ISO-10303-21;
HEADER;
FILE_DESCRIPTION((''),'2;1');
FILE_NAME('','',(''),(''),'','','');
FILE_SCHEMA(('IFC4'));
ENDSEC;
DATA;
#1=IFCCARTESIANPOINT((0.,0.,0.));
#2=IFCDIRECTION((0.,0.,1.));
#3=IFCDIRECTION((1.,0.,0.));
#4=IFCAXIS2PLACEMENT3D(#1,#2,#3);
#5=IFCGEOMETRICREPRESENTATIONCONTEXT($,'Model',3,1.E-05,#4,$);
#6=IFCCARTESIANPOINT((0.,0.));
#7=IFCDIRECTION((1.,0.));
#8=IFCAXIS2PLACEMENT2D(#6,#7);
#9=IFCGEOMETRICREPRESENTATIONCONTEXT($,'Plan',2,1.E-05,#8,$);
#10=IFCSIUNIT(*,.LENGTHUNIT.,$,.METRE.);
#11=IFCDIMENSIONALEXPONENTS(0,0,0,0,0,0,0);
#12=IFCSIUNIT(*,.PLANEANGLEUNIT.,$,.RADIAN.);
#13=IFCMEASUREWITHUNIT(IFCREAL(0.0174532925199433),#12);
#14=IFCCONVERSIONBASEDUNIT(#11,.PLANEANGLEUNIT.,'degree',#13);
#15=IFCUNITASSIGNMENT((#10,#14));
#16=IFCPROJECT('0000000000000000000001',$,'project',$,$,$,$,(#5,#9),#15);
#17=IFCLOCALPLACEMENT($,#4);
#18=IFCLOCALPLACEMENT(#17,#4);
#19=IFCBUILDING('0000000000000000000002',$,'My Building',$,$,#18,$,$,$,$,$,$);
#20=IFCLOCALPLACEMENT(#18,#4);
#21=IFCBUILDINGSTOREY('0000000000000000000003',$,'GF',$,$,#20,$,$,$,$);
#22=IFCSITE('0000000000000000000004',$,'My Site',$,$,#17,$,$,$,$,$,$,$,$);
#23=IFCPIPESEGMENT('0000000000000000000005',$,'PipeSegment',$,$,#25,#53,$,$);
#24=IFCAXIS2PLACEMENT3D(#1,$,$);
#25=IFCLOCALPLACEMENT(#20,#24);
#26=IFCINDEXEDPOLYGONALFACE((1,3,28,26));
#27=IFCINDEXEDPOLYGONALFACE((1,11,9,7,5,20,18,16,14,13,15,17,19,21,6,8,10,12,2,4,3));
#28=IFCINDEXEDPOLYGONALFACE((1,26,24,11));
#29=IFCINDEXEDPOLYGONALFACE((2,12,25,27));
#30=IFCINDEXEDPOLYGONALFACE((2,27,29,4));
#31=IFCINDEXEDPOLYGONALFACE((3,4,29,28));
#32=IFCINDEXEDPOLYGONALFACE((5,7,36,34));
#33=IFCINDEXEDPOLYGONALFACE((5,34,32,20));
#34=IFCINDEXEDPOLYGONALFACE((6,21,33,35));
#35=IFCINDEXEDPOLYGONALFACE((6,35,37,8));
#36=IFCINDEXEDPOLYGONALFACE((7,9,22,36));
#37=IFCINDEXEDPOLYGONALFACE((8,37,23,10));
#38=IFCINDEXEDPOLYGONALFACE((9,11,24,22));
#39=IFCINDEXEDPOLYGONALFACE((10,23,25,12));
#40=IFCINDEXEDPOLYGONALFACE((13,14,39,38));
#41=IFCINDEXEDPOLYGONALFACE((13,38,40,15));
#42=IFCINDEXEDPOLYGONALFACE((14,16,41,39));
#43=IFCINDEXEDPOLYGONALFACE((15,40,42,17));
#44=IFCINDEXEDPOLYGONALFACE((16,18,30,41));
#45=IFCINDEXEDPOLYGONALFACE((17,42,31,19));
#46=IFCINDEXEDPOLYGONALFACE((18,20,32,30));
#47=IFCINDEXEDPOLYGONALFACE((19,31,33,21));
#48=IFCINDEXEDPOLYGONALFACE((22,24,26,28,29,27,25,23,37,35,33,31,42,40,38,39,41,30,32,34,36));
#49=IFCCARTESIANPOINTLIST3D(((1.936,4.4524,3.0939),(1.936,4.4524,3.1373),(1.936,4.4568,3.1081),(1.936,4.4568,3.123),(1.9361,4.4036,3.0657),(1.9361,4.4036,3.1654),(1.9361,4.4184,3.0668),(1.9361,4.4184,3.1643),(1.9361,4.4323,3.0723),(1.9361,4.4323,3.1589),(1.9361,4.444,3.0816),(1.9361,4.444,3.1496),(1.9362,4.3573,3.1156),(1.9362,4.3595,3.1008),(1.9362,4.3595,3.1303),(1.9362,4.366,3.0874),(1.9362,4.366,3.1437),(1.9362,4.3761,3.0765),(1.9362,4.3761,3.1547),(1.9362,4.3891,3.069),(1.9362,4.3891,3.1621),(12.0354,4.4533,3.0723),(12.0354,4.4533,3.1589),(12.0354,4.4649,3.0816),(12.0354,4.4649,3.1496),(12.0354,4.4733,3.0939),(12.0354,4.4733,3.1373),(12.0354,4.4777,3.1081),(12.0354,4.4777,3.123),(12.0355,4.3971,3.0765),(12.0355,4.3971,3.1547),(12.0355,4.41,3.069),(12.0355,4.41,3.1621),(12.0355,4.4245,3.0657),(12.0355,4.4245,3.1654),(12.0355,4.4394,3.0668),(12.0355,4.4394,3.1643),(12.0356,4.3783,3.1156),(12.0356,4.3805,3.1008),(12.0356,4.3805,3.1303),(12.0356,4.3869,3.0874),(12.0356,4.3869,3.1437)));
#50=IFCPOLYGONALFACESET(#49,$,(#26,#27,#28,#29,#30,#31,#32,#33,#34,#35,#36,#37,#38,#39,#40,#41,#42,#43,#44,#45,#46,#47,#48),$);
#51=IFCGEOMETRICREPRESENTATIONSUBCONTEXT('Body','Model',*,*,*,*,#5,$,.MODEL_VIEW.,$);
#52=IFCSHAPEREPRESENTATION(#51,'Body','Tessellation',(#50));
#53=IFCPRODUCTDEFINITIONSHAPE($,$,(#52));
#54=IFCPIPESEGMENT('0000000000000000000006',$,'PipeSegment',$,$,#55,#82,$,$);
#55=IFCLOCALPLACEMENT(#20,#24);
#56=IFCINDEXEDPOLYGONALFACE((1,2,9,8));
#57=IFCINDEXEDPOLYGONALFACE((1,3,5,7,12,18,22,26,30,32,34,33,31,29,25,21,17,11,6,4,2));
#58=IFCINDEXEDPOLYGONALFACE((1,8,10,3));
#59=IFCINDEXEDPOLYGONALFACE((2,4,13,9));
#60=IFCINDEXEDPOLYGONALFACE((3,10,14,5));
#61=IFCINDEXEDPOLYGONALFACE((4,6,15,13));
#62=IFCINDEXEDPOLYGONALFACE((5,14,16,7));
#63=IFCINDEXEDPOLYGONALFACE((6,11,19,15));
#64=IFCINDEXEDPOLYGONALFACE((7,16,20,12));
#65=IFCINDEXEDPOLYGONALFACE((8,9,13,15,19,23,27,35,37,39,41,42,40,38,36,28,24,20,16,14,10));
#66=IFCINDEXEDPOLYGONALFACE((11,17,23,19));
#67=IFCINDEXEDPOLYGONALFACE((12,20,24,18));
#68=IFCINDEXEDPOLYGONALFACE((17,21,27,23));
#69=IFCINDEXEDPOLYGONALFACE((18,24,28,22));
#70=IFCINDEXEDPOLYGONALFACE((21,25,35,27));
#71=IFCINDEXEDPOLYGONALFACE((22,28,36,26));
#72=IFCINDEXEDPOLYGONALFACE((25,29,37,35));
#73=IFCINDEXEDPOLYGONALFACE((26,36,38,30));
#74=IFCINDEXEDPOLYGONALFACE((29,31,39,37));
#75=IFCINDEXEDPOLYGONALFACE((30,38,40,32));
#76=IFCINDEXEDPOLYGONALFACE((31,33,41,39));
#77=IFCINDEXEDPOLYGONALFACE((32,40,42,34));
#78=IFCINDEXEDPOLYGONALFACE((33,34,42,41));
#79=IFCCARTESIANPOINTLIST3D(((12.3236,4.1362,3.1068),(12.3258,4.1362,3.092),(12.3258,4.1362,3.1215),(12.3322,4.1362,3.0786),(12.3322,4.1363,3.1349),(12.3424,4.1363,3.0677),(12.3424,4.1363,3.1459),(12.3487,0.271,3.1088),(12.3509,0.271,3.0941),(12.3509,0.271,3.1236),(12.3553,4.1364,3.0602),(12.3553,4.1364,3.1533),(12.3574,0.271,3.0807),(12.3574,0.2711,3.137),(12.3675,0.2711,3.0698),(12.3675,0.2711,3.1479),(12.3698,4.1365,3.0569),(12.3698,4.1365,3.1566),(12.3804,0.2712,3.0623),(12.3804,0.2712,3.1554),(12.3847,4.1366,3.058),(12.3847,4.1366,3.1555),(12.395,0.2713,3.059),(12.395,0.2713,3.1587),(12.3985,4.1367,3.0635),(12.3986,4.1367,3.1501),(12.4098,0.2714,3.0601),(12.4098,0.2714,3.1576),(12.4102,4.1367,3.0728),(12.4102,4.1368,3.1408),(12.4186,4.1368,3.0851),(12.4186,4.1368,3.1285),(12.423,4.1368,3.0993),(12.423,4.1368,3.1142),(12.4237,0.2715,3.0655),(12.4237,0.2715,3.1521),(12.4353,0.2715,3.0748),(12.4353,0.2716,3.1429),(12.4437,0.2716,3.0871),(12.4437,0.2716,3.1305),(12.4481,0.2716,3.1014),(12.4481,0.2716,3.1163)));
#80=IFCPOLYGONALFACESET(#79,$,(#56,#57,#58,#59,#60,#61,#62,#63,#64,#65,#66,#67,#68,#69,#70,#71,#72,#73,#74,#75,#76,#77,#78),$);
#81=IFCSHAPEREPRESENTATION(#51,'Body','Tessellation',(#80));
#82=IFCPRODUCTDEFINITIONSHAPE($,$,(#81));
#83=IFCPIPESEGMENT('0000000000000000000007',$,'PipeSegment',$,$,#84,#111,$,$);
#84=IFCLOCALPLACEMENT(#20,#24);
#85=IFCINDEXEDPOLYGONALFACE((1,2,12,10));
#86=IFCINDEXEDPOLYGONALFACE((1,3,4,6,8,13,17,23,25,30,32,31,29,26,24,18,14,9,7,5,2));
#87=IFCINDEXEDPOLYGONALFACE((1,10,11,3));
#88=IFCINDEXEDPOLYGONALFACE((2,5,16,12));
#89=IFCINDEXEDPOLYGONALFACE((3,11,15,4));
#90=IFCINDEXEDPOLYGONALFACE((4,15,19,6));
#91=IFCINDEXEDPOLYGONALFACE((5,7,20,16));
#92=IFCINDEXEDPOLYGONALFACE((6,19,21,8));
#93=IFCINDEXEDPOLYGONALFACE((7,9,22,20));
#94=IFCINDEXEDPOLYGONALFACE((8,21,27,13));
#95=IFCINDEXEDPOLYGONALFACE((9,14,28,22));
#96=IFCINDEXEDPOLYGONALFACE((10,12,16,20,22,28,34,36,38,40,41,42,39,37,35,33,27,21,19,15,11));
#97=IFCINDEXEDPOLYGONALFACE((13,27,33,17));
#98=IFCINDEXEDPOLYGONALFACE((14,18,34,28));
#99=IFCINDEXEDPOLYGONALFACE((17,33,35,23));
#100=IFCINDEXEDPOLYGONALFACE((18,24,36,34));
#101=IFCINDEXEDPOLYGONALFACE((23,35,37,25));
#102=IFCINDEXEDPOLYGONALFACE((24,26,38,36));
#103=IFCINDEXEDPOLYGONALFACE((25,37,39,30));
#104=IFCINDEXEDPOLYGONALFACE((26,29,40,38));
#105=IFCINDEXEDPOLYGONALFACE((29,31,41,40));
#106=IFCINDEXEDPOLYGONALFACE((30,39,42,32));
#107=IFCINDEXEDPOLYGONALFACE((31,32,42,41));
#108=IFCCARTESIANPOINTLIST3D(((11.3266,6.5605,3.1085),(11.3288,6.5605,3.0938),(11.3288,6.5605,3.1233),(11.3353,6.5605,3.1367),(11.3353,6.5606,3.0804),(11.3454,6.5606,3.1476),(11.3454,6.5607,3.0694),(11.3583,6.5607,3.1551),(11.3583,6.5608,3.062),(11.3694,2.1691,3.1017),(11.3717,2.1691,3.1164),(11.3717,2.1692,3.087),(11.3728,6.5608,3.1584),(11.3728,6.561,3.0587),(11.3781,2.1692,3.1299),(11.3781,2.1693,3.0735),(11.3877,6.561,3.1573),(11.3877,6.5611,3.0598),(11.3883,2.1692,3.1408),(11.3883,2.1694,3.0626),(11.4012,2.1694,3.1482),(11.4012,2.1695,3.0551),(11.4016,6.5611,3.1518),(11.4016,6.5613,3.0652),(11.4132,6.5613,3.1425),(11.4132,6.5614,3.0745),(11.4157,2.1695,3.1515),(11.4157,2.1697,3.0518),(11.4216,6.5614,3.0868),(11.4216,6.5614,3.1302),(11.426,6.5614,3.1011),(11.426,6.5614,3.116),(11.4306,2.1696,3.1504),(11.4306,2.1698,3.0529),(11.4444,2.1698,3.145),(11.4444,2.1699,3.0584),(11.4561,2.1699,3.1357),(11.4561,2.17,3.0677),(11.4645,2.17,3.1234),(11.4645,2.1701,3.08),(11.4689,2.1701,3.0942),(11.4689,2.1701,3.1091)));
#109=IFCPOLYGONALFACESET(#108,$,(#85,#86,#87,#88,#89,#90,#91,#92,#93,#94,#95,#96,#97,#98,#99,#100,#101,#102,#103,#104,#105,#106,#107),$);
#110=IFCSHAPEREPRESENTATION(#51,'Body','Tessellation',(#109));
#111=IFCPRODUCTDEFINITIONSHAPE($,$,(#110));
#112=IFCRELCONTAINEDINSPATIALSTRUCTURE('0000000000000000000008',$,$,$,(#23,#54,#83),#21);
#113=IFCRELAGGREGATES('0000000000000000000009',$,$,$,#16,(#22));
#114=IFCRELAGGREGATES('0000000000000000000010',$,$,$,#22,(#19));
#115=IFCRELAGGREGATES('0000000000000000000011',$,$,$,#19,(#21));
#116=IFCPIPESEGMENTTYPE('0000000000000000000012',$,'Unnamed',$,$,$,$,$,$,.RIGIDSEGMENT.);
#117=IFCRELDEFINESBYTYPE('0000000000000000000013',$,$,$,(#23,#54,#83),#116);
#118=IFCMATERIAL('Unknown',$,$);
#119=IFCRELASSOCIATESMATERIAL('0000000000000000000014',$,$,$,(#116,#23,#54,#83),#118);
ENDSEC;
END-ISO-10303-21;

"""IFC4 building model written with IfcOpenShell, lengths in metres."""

from ifc_helpers import new_model, entity, si_unit, converted_unit, frame, origin_with_axes, origin_2d_with_axis, place, context, subcontext, project, spatial, circle, extrude, material, material_profile, profile_set, profile_usage, type_object, element, save


model = new_model("IFC4")

# Units and contexts
model_context = context("Model", 3, precision=1e-05, world=origin_with_axes())
plan_context = context("Plan", 2, precision=1e-05, world=origin_2d_with_axis())
body_context_1 = subcontext(model_context, "Body", "Model", "MODEL_VIEW")
ifc_project = project(units=[si_unit("LENGTHUNIT", "METRE"), converted_unit("PLANEANGLEUNIT", "degree", entity("IfcReal", 0.0174532925199433), si_unit("PLANEANGLEUNIT", "RADIAN"), dimensions=[0, 0, 0, 0, 0, 0, 0])], contexts=[model_context, plan_context])

# Site, building, storey
site_placement = place(None, origin_with_axes())
site = spatial("IfcSite", under=ifc_project, at=site_placement, Name="My Site")
building_placement = place(site_placement, origin_with_axes())
building = spatial("IfcBuilding", under=site, at=building_placement, Name="My Building")
storey_placement = place(building_placement, origin_with_axes())
storey = spatial("IfcBuildingStorey", under=building, at=storey_placement, Name="GF")

# Shared definitions
ifc_material = material(Name="Unknown")

# Pipe segments
ifc_material_profile = material_profile(ifc_material, circle(Radius=0.05))
ifc_profile_set = profile_set([ifc_material_profile])
pipe_segment_type = type_object("IfcPipeSegmentType", Name="Unnamed", PredefinedType="RIGIDSEGMENT", material=ifc_profile_set)
ifc_profile_usage_1 = profile_usage(ifc_profile_set, cardinal=5)
pipe_segment_1_placement = place(storey_placement, frame((12.0355, 4.4283, 3.1156), z_axis=(-0.999998, -0.002073, 0.0), x_axis=(0.002073, -0.999998, 0.0)))
element("IfcPipeSegment", 1, at=pipe_segment_1_placement, inside=storey, type_object=pipe_segment_type, material=ifc_profile_usage_1, Name="PipeSegment", context=body_context_1, shape_type="SweptSolid", body=[
    extrude(circle(Radius=0.05), origin_with_axes(), (0.0, 0.0, 1.0), 10.0994),
])
ifc_profile_usage_2 = profile_usage(ifc_profile_set, cardinal=5)
pipe_segment_2_placement = place(storey_placement, frame((12.3987, 0.2713, 3.1088), z_axis=(-0.006505, 0.999979, -0.000534), x_axis=(-0.999979, -0.006505, 0.000076)))
element("IfcPipeSegment", 2, at=pipe_segment_2_placement, inside=storey, type_object=pipe_segment_type, material=ifc_profile_usage_2, Name="PipeSegment", context=body_context_1, shape_type="SweptSolid", body=[
    extrude(circle(Radius=0.05), origin_with_axes(), (0.0, 0.0, 1.0), 3.8653),
])
ifc_profile_usage_3 = profile_usage(ifc_profile_set, cardinal=5)
pipe_segment_3_placement = place(storey_placement, frame((11.4194, 2.1696, 3.1017), z_axis=(-0.00976, 0.999951, 0.001558), x_axis=(-0.999952, -0.00976, 0.0)))
element("IfcPipeSegment", 3, at=pipe_segment_3_placement, inside=storey, type_object=pipe_segment_type, material=ifc_profile_usage_3, Name="PipeSegment", context=body_context_1, shape_type="SweptSolid", body=[
    extrude(circle(Radius=0.05), origin_with_axes(), (0.0, 0.0, 1.0), 4.3916),
])

save(model, "model.ifc")
